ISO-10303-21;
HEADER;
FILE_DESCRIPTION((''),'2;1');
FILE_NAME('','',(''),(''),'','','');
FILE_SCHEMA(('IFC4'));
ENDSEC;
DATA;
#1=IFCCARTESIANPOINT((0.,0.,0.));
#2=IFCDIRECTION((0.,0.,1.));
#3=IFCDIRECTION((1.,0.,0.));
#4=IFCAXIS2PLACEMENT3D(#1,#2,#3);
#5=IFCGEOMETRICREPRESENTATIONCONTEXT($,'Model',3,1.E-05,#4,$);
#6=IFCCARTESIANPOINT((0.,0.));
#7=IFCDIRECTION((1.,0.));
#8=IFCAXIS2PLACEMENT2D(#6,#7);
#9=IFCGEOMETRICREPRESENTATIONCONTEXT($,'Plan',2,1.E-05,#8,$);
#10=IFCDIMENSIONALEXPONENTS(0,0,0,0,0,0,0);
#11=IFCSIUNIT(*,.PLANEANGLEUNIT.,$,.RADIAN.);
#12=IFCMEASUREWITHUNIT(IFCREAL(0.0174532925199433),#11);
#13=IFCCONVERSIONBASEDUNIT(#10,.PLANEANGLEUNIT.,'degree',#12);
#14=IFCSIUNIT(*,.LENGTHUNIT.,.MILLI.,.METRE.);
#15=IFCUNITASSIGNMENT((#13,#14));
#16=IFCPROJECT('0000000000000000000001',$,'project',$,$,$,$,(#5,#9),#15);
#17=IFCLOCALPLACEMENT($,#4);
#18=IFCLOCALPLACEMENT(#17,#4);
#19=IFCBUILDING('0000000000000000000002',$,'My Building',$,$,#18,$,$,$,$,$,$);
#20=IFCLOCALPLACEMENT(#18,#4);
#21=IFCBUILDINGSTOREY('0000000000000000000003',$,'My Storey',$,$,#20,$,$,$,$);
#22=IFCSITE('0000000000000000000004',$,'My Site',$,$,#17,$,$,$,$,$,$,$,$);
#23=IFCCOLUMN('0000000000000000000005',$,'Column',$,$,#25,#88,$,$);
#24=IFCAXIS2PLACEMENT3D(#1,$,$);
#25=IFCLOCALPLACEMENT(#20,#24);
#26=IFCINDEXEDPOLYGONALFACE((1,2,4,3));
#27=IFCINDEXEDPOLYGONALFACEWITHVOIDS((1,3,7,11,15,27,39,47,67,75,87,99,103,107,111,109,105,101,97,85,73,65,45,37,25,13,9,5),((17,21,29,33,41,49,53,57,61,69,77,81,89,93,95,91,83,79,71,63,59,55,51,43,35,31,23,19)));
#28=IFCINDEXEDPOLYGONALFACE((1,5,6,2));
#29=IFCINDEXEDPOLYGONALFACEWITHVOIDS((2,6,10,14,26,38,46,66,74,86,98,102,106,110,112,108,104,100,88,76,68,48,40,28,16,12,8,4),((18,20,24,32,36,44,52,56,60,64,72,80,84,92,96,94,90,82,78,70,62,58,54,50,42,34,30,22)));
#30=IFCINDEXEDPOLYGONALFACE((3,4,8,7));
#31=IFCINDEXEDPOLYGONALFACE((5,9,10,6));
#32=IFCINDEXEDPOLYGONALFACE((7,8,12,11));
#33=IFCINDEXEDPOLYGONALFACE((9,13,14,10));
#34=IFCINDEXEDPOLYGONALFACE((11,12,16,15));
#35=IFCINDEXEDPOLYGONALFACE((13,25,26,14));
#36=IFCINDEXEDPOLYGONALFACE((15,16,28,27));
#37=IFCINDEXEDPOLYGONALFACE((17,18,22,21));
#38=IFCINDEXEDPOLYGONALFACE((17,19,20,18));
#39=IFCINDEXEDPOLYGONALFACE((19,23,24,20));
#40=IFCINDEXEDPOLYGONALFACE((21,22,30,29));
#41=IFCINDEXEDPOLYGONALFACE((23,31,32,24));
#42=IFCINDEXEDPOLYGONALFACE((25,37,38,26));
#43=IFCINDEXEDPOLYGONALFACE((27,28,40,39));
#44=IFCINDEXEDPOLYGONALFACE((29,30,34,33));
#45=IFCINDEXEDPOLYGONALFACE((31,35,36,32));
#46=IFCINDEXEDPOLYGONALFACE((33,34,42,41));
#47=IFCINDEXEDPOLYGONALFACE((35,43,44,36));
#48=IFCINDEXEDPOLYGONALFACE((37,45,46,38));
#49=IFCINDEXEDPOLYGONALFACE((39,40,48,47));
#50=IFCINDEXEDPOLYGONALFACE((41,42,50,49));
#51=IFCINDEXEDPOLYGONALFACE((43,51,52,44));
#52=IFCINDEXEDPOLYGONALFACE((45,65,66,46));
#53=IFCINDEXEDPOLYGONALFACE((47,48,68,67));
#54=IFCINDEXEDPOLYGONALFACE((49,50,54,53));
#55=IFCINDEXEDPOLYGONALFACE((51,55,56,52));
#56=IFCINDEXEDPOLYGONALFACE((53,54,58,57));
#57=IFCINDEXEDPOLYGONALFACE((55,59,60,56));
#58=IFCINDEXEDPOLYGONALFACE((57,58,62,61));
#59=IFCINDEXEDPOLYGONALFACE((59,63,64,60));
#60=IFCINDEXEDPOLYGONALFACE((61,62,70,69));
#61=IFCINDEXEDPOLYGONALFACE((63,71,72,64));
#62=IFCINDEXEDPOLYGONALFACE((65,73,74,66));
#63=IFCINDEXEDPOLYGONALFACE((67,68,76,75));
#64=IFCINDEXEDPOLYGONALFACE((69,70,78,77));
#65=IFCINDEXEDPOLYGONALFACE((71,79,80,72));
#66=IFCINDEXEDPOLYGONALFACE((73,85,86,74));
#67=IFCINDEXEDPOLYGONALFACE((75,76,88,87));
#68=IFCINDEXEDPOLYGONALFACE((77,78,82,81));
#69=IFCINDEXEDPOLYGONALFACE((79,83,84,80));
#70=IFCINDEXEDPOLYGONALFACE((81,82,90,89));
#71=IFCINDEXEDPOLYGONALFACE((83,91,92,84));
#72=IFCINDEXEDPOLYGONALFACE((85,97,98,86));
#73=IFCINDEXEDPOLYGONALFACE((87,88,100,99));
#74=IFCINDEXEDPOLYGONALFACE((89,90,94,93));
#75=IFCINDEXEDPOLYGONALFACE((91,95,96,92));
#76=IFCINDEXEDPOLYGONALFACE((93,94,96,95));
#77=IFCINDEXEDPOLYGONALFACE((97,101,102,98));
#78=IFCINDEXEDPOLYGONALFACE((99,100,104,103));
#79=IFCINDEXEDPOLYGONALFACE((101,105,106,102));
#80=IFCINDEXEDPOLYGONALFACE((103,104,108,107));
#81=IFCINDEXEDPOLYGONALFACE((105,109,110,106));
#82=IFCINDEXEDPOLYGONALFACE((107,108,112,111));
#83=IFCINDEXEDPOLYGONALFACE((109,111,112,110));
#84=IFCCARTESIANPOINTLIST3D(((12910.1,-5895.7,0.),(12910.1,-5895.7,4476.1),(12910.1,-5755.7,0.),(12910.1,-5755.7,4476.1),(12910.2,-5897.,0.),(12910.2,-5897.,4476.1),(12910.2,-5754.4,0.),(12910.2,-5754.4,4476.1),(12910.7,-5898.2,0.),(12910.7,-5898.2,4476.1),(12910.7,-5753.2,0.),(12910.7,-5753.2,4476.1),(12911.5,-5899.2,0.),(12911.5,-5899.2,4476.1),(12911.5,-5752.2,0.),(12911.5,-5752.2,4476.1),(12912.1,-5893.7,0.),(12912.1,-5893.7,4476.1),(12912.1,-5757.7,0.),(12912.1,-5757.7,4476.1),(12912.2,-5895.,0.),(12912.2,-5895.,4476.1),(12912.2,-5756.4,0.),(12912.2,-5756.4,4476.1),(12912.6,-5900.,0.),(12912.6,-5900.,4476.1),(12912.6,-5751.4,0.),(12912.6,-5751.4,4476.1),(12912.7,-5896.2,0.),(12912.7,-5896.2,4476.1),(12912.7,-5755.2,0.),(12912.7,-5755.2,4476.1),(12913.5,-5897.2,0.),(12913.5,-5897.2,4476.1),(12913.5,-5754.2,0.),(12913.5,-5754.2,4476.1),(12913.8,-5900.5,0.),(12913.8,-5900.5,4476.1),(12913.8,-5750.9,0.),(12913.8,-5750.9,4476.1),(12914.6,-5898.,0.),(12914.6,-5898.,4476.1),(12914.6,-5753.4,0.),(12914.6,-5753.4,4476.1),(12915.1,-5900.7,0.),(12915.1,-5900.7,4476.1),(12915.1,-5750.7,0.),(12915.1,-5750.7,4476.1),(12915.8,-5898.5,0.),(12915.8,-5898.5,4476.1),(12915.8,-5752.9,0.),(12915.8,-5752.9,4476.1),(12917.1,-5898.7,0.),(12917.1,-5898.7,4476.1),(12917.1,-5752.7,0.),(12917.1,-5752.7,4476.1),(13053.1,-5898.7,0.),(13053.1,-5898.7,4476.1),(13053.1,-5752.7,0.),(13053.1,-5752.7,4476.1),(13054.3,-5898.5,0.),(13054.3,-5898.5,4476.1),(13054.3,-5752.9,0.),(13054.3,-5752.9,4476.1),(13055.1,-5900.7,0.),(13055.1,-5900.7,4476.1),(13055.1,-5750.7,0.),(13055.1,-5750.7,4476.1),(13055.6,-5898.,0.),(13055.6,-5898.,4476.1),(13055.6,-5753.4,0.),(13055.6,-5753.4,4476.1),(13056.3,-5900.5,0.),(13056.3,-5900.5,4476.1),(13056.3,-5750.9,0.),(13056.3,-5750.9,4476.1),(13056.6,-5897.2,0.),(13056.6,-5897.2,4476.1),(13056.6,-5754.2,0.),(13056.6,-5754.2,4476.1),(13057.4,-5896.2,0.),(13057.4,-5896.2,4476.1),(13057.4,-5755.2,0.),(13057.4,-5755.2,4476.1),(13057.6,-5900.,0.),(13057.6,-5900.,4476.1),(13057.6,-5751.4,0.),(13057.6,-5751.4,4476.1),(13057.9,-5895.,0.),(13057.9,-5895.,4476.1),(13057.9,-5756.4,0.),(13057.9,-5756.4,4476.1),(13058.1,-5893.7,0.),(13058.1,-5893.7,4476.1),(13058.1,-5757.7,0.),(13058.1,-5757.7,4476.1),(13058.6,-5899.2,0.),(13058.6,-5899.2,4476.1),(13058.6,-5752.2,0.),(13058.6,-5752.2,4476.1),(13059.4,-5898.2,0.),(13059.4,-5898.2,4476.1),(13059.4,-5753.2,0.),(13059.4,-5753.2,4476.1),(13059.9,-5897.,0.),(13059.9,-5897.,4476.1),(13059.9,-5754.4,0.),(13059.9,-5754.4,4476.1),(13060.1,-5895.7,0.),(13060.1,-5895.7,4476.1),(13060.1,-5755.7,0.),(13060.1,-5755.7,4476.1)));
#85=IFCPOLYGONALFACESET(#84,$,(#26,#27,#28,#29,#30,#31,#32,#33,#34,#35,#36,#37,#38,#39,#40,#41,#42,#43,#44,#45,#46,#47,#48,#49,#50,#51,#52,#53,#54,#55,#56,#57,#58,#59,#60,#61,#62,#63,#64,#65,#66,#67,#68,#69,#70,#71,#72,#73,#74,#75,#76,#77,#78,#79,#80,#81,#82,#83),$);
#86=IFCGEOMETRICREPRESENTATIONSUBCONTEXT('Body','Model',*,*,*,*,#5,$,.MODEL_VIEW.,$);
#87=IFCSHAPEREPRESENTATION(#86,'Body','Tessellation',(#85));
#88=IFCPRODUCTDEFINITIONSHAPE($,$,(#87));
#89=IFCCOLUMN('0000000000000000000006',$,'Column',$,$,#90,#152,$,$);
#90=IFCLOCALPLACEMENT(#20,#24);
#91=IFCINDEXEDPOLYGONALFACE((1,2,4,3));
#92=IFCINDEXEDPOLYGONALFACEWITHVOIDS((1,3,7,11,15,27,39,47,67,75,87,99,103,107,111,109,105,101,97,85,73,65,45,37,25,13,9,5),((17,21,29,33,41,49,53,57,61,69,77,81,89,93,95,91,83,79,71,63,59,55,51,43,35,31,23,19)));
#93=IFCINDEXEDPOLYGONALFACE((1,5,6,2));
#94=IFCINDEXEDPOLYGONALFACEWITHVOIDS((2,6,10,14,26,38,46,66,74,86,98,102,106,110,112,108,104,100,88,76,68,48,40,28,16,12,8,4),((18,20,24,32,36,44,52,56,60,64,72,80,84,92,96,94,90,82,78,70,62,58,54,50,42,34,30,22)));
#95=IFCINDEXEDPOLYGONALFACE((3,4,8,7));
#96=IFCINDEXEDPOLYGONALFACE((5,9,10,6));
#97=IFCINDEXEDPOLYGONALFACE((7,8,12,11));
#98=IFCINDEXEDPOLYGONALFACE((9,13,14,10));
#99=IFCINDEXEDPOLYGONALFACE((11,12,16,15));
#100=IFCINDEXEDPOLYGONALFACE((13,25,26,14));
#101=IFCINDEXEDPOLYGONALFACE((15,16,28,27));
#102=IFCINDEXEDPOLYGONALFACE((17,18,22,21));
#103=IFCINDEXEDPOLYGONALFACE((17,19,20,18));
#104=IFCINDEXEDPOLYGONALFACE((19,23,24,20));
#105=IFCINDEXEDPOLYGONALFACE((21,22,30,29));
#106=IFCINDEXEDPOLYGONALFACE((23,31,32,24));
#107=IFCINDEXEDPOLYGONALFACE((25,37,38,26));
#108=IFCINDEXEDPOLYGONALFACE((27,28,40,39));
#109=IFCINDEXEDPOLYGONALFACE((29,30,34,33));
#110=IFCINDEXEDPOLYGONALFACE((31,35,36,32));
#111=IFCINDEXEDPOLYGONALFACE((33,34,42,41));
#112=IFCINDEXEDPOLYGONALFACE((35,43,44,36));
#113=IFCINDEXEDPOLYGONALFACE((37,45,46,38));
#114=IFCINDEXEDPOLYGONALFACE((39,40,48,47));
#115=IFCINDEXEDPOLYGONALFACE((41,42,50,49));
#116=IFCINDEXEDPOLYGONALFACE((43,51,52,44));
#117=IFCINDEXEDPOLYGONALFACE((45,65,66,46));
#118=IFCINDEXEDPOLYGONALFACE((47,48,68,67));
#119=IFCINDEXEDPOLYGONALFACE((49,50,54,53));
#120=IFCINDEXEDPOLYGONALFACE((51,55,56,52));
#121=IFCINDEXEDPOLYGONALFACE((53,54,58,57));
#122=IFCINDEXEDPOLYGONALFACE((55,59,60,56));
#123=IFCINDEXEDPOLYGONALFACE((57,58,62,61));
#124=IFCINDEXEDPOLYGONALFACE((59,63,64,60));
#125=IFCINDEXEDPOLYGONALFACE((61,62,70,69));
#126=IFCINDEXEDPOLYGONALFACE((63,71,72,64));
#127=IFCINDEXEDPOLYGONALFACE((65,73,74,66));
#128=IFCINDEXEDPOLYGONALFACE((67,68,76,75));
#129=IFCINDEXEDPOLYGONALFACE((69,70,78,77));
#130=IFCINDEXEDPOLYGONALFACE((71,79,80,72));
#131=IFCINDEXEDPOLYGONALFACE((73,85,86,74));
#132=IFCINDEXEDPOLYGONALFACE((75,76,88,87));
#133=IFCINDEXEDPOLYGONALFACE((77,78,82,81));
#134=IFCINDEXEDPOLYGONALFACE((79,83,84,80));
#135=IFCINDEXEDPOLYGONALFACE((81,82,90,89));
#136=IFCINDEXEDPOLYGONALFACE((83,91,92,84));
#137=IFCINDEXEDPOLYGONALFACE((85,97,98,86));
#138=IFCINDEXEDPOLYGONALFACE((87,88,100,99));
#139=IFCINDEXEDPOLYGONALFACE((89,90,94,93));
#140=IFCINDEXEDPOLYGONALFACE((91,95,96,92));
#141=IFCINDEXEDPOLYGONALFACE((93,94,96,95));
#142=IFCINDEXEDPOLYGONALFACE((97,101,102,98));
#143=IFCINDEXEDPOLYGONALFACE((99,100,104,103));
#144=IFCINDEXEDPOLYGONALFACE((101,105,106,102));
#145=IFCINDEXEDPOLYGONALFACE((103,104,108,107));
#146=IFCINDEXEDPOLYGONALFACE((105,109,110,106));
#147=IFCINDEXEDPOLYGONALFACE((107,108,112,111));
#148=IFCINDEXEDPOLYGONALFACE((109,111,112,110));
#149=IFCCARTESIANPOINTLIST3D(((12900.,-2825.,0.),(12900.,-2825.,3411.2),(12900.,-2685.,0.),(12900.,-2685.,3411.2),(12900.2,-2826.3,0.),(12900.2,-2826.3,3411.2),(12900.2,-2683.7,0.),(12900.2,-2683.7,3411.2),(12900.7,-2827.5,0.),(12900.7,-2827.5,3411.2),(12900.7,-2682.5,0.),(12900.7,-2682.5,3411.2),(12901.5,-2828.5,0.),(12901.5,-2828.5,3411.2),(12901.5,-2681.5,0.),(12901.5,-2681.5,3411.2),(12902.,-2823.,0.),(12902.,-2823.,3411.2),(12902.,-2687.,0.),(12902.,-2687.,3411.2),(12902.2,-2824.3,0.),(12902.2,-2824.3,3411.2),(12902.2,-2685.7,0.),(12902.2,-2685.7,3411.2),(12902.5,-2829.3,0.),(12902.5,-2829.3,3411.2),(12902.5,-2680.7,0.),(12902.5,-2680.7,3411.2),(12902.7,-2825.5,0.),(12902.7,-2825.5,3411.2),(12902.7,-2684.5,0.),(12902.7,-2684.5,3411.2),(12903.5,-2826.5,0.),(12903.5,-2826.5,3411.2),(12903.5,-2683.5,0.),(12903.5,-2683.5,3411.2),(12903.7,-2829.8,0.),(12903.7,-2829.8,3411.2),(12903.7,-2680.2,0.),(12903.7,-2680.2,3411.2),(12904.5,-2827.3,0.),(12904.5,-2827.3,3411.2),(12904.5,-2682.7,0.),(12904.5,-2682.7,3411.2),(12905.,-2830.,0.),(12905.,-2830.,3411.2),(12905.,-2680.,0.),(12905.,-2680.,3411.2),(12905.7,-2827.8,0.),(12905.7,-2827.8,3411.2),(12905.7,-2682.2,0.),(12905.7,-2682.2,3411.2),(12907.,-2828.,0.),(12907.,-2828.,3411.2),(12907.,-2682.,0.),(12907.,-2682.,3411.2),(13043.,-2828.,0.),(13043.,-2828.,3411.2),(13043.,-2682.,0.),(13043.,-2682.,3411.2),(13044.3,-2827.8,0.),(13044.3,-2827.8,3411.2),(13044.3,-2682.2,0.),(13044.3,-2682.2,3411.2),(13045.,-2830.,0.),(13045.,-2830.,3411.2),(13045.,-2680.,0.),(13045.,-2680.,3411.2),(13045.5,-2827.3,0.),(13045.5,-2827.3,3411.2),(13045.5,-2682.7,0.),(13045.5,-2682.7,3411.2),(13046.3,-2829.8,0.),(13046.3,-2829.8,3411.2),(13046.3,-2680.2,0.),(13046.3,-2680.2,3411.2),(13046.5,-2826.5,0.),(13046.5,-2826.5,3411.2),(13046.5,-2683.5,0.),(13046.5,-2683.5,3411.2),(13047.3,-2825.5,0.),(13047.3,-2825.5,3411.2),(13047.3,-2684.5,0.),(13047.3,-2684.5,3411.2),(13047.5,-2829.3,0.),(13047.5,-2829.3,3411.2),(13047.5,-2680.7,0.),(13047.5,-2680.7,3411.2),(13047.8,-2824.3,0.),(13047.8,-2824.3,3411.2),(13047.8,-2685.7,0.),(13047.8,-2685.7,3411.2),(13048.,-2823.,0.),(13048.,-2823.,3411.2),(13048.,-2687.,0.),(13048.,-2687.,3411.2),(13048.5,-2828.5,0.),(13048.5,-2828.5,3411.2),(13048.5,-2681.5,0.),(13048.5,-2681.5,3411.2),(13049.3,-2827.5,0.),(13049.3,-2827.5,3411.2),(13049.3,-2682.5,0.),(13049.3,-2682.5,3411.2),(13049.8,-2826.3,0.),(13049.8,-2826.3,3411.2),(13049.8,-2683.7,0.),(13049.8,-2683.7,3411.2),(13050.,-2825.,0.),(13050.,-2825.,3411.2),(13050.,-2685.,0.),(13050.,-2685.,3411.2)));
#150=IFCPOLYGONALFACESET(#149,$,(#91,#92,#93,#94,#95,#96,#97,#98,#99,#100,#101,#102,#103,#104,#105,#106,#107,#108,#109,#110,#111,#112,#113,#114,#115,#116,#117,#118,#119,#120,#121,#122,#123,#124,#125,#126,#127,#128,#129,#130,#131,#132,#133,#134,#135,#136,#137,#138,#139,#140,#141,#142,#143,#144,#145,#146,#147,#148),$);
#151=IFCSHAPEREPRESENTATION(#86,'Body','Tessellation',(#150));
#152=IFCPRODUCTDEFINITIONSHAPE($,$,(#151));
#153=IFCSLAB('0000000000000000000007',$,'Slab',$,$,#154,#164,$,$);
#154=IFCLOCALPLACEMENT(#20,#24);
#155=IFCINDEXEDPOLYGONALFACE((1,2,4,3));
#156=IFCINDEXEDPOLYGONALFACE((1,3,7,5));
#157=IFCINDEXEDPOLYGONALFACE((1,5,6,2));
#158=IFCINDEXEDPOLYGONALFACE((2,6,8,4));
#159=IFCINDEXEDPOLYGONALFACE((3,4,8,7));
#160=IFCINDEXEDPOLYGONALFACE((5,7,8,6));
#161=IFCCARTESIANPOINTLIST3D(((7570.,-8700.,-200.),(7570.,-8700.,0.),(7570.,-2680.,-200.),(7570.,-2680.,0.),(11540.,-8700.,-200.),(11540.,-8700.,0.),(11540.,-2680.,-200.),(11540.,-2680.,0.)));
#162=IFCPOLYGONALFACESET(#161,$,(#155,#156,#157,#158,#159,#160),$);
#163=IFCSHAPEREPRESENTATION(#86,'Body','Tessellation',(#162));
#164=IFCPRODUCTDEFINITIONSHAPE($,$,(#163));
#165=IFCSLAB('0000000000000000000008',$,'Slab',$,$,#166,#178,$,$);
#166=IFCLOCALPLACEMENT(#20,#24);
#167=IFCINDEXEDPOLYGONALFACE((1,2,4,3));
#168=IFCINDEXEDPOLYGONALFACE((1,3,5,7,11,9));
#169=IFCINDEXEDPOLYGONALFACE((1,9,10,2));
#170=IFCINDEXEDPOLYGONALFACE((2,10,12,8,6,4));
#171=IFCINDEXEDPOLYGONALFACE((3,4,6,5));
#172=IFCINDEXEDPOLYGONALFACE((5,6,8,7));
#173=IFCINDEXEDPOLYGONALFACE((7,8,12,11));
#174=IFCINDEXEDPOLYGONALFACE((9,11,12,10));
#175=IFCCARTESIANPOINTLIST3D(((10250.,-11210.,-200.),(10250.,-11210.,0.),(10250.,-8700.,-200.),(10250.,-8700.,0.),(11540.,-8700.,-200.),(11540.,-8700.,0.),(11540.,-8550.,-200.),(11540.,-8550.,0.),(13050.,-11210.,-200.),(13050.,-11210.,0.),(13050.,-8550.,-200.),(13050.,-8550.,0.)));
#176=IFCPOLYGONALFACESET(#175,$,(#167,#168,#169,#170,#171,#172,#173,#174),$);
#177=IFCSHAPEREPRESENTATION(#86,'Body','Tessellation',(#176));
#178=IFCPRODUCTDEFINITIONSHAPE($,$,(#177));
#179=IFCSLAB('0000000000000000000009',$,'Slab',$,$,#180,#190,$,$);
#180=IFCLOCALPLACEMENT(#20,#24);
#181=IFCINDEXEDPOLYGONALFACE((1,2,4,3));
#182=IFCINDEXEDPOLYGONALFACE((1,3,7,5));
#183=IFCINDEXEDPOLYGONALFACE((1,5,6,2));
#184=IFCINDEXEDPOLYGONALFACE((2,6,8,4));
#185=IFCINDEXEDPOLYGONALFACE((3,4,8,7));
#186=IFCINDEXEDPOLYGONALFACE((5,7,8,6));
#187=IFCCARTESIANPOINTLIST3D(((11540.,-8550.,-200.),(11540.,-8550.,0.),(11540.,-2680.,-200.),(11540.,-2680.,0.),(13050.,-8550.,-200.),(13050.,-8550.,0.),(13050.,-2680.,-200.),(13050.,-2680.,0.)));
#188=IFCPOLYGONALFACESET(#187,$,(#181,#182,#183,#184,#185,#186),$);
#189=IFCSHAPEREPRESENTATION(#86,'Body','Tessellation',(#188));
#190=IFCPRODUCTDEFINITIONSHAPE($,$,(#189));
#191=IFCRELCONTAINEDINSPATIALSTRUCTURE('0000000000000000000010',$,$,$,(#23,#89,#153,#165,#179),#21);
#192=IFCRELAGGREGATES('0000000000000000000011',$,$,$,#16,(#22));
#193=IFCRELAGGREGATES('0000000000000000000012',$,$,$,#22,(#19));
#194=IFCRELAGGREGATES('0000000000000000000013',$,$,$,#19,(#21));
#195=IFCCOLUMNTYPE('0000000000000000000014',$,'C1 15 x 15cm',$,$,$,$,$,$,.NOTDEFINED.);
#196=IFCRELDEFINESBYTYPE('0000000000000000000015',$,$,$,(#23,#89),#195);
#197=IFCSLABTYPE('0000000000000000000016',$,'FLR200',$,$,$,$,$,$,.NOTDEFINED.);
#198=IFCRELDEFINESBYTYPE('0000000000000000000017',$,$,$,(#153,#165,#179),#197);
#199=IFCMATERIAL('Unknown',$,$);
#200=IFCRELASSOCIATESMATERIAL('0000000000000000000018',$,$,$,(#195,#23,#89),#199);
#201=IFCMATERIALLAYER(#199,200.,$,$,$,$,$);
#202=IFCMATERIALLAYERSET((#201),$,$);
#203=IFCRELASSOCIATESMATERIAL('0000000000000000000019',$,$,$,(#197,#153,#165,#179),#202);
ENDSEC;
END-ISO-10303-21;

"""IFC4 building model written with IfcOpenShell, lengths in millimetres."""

from ifc_helpers import new_model, entity, si_unit, converted_unit, frame, origin_with_axes, origin_2d_with_axis, place, context, subcontext, project, spatial, indexed_curve, hollow_rectangle, outline, extrude, material, layer, layer_set, layer_usage, material_profile, profile_set, profile_usage, type_object, element, save


model = new_model("IFC4")

# Units and contexts
model_context = context("Model", 3, precision=1e-05, world=origin_with_axes())
plan_context = context("Plan", 2, precision=1e-05, world=origin_2d_with_axis())
body_context_1 = subcontext(model_context, "Body", "Model", "MODEL_VIEW")
ifc_project = project(units=[converted_unit("PLANEANGLEUNIT", "degree", entity("IfcReal", 0.0174532925199433), si_unit("PLANEANGLEUNIT", "RADIAN"), dimensions=[0, 0, 0, 0, 0, 0, 0]), si_unit("LENGTHUNIT", "METRE", prefix="MILLI")], contexts=[model_context, plan_context])

# Site, building, storey
site_placement = place(None, origin_with_axes())
site = spatial("IfcSite", under=ifc_project, at=site_placement, Name="My Site")
building_placement = place(site_placement, origin_with_axes())
building = spatial("IfcBuilding", under=site, at=building_placement, Name="My Building")
storey_placement = place(building_placement, origin_with_axes())
storey = spatial("IfcBuildingStorey", under=building, at=storey_placement, Name="My Storey")

# Columns
ifc_material = material(Name="Unknown")
ifc_material_profile = material_profile(ifc_material, hollow_rectangle(XDim=150.0, YDim=150.0, WallThickness=2.0, InnerFilletRadius=5.0, OuterFilletRadius=5.0))
ifc_profile_set = profile_set([ifc_material_profile])
ifc_profile_usage_1 = profile_usage(ifc_profile_set, cardinal=5)
column_type = type_object("IfcColumnType", Name="C1 15 x 15cm", PredefinedType="NOTDEFINED", material=ifc_profile_set)
column_1_placement = place(storey_placement, frame((12985.1, -5825.7, 0.0), z_axis=(0.0, 0.0, 1.0), x_axis=(1.0, 0.0, 0.0)))
element("IfcColumn", 1, at=column_1_placement, inside=storey, type_object=column_type, material=ifc_profile_usage_1, Name="Column", context=body_context_1, shape_type="SweptSolid", body=[
    extrude(hollow_rectangle(XDim=150.0, YDim=150.0, WallThickness=2.0, InnerFilletRadius=5.0, OuterFilletRadius=5.0), origin_with_axes(), (0.0, 0.0, 1.0), 4476.1),
])
ifc_profile_usage_2 = profile_usage(ifc_profile_set, cardinal=5)
column_2_placement = place(storey_placement, frame((12975.0, -2755.0, 0.0), z_axis=(0.0, 0.0, 1.0), x_axis=(1.0, 0.0, 0.0)))
element("IfcColumn", 2, at=column_2_placement, inside=storey, type_object=column_type, material=ifc_profile_usage_2, Name="Column", context=body_context_1, shape_type="SweptSolid", body=[
    extrude(hollow_rectangle(XDim=150.0, YDim=150.0, WallThickness=2.0, InnerFilletRadius=5.0, OuterFilletRadius=5.0), origin_with_axes(), (0.0, 0.0, 1.0), 3411.2),
])

# Slabs
ifc_layer_1 = layer(ifc_material, 200.0)
ifc_layer_set_1 = layer_set([ifc_layer_1])
ifc_layer_usage_1 = layer_usage(ifc_layer_set_1, "AXIS3", "POSITIVE", -200.0)
slab_type = type_object("IfcSlabType", Name="FLR200", PredefinedType="NOTDEFINED", material=ifc_layer_set_1)
slab_1_placement = place(storey_placement, frame((7570.0, -8700.0, 0.0), z_axis=(0.0, 0.0, 1.0), x_axis=(1.0, 0.0, 0.0)))
element("IfcSlab", 3, at=slab_1_placement, inside=storey, type_object=slab_type, material=ifc_layer_usage_1, Name="Slab", context=body_context_1, shape_type="SweptSolid", body=[
    extrude(outline(indexed_curve([(0.0, 0.0), (3970.0, 0.0), (3970.0, 6020.0), (0.0, 6020.0), (0.0, 0.0)])), frame((0.0, 0.0, -200.0), z_axis=(0.0, 0.0, 1.0), x_axis=(1.0, 0.0, 0.0)), (0.0, 0.0, 1.0), 200.0),
])
ifc_layer_usage_2 = layer_usage(ifc_layer_set_1, "AXIS3", "POSITIVE", -200.0)
slab_2_placement = place(storey_placement, frame((11540.0, -8550.0, 0.0), z_axis=(0.0, 0.0, 1.0), x_axis=(1.0, 0.0, 0.0)))
element("IfcSlab", 4, at=slab_2_placement, inside=storey, type_object=slab_type, material=ifc_layer_usage_2, Name="Slab", context=body_context_1, shape_type="SweptSolid", body=[
    extrude(outline(indexed_curve([(0.0, 0.0), (1510.0, 0.0), (1510.0, -2660.0), (-1290.0, -2660.0), (-1290.0, -150.0), (0.0, -150.0), (0.0, 0.0)])), frame((0.0, 0.0, -200.0), z_axis=(0.0, 0.0, 1.0), x_axis=(1.0, 0.0, 0.0)), (0.0, 0.0, 1.0), 200.0),
])
ifc_layer_usage_3 = layer_usage(ifc_layer_set_1, "AXIS3", "POSITIVE", -200.0)
slab_3_placement = place(storey_placement, frame((11540.0, -8550.0, 0.0), z_axis=(0.0, 0.0, 1.0), x_axis=(1.0, 0.0, 0.0)))
element("IfcSlab", 5, at=slab_3_placement, inside=storey, type_object=slab_type, material=ifc_layer_usage_3, Name="Slab", context=body_context_1, shape_type="SweptSolid", body=[
    extrude(outline(indexed_curve([(0.0, 0.0), (1510.0, 0.0), (1510.0, 5870.0), (0.0, 5870.0), (0.0, 0.0)])), frame((0.0, 0.0, -200.0), z_axis=(0.0, 0.0, 1.0), x_axis=(1.0, 0.0, 0.0)), (0.0, 0.0, 1.0), 200.0),
])

save(model, "model.ifc")
